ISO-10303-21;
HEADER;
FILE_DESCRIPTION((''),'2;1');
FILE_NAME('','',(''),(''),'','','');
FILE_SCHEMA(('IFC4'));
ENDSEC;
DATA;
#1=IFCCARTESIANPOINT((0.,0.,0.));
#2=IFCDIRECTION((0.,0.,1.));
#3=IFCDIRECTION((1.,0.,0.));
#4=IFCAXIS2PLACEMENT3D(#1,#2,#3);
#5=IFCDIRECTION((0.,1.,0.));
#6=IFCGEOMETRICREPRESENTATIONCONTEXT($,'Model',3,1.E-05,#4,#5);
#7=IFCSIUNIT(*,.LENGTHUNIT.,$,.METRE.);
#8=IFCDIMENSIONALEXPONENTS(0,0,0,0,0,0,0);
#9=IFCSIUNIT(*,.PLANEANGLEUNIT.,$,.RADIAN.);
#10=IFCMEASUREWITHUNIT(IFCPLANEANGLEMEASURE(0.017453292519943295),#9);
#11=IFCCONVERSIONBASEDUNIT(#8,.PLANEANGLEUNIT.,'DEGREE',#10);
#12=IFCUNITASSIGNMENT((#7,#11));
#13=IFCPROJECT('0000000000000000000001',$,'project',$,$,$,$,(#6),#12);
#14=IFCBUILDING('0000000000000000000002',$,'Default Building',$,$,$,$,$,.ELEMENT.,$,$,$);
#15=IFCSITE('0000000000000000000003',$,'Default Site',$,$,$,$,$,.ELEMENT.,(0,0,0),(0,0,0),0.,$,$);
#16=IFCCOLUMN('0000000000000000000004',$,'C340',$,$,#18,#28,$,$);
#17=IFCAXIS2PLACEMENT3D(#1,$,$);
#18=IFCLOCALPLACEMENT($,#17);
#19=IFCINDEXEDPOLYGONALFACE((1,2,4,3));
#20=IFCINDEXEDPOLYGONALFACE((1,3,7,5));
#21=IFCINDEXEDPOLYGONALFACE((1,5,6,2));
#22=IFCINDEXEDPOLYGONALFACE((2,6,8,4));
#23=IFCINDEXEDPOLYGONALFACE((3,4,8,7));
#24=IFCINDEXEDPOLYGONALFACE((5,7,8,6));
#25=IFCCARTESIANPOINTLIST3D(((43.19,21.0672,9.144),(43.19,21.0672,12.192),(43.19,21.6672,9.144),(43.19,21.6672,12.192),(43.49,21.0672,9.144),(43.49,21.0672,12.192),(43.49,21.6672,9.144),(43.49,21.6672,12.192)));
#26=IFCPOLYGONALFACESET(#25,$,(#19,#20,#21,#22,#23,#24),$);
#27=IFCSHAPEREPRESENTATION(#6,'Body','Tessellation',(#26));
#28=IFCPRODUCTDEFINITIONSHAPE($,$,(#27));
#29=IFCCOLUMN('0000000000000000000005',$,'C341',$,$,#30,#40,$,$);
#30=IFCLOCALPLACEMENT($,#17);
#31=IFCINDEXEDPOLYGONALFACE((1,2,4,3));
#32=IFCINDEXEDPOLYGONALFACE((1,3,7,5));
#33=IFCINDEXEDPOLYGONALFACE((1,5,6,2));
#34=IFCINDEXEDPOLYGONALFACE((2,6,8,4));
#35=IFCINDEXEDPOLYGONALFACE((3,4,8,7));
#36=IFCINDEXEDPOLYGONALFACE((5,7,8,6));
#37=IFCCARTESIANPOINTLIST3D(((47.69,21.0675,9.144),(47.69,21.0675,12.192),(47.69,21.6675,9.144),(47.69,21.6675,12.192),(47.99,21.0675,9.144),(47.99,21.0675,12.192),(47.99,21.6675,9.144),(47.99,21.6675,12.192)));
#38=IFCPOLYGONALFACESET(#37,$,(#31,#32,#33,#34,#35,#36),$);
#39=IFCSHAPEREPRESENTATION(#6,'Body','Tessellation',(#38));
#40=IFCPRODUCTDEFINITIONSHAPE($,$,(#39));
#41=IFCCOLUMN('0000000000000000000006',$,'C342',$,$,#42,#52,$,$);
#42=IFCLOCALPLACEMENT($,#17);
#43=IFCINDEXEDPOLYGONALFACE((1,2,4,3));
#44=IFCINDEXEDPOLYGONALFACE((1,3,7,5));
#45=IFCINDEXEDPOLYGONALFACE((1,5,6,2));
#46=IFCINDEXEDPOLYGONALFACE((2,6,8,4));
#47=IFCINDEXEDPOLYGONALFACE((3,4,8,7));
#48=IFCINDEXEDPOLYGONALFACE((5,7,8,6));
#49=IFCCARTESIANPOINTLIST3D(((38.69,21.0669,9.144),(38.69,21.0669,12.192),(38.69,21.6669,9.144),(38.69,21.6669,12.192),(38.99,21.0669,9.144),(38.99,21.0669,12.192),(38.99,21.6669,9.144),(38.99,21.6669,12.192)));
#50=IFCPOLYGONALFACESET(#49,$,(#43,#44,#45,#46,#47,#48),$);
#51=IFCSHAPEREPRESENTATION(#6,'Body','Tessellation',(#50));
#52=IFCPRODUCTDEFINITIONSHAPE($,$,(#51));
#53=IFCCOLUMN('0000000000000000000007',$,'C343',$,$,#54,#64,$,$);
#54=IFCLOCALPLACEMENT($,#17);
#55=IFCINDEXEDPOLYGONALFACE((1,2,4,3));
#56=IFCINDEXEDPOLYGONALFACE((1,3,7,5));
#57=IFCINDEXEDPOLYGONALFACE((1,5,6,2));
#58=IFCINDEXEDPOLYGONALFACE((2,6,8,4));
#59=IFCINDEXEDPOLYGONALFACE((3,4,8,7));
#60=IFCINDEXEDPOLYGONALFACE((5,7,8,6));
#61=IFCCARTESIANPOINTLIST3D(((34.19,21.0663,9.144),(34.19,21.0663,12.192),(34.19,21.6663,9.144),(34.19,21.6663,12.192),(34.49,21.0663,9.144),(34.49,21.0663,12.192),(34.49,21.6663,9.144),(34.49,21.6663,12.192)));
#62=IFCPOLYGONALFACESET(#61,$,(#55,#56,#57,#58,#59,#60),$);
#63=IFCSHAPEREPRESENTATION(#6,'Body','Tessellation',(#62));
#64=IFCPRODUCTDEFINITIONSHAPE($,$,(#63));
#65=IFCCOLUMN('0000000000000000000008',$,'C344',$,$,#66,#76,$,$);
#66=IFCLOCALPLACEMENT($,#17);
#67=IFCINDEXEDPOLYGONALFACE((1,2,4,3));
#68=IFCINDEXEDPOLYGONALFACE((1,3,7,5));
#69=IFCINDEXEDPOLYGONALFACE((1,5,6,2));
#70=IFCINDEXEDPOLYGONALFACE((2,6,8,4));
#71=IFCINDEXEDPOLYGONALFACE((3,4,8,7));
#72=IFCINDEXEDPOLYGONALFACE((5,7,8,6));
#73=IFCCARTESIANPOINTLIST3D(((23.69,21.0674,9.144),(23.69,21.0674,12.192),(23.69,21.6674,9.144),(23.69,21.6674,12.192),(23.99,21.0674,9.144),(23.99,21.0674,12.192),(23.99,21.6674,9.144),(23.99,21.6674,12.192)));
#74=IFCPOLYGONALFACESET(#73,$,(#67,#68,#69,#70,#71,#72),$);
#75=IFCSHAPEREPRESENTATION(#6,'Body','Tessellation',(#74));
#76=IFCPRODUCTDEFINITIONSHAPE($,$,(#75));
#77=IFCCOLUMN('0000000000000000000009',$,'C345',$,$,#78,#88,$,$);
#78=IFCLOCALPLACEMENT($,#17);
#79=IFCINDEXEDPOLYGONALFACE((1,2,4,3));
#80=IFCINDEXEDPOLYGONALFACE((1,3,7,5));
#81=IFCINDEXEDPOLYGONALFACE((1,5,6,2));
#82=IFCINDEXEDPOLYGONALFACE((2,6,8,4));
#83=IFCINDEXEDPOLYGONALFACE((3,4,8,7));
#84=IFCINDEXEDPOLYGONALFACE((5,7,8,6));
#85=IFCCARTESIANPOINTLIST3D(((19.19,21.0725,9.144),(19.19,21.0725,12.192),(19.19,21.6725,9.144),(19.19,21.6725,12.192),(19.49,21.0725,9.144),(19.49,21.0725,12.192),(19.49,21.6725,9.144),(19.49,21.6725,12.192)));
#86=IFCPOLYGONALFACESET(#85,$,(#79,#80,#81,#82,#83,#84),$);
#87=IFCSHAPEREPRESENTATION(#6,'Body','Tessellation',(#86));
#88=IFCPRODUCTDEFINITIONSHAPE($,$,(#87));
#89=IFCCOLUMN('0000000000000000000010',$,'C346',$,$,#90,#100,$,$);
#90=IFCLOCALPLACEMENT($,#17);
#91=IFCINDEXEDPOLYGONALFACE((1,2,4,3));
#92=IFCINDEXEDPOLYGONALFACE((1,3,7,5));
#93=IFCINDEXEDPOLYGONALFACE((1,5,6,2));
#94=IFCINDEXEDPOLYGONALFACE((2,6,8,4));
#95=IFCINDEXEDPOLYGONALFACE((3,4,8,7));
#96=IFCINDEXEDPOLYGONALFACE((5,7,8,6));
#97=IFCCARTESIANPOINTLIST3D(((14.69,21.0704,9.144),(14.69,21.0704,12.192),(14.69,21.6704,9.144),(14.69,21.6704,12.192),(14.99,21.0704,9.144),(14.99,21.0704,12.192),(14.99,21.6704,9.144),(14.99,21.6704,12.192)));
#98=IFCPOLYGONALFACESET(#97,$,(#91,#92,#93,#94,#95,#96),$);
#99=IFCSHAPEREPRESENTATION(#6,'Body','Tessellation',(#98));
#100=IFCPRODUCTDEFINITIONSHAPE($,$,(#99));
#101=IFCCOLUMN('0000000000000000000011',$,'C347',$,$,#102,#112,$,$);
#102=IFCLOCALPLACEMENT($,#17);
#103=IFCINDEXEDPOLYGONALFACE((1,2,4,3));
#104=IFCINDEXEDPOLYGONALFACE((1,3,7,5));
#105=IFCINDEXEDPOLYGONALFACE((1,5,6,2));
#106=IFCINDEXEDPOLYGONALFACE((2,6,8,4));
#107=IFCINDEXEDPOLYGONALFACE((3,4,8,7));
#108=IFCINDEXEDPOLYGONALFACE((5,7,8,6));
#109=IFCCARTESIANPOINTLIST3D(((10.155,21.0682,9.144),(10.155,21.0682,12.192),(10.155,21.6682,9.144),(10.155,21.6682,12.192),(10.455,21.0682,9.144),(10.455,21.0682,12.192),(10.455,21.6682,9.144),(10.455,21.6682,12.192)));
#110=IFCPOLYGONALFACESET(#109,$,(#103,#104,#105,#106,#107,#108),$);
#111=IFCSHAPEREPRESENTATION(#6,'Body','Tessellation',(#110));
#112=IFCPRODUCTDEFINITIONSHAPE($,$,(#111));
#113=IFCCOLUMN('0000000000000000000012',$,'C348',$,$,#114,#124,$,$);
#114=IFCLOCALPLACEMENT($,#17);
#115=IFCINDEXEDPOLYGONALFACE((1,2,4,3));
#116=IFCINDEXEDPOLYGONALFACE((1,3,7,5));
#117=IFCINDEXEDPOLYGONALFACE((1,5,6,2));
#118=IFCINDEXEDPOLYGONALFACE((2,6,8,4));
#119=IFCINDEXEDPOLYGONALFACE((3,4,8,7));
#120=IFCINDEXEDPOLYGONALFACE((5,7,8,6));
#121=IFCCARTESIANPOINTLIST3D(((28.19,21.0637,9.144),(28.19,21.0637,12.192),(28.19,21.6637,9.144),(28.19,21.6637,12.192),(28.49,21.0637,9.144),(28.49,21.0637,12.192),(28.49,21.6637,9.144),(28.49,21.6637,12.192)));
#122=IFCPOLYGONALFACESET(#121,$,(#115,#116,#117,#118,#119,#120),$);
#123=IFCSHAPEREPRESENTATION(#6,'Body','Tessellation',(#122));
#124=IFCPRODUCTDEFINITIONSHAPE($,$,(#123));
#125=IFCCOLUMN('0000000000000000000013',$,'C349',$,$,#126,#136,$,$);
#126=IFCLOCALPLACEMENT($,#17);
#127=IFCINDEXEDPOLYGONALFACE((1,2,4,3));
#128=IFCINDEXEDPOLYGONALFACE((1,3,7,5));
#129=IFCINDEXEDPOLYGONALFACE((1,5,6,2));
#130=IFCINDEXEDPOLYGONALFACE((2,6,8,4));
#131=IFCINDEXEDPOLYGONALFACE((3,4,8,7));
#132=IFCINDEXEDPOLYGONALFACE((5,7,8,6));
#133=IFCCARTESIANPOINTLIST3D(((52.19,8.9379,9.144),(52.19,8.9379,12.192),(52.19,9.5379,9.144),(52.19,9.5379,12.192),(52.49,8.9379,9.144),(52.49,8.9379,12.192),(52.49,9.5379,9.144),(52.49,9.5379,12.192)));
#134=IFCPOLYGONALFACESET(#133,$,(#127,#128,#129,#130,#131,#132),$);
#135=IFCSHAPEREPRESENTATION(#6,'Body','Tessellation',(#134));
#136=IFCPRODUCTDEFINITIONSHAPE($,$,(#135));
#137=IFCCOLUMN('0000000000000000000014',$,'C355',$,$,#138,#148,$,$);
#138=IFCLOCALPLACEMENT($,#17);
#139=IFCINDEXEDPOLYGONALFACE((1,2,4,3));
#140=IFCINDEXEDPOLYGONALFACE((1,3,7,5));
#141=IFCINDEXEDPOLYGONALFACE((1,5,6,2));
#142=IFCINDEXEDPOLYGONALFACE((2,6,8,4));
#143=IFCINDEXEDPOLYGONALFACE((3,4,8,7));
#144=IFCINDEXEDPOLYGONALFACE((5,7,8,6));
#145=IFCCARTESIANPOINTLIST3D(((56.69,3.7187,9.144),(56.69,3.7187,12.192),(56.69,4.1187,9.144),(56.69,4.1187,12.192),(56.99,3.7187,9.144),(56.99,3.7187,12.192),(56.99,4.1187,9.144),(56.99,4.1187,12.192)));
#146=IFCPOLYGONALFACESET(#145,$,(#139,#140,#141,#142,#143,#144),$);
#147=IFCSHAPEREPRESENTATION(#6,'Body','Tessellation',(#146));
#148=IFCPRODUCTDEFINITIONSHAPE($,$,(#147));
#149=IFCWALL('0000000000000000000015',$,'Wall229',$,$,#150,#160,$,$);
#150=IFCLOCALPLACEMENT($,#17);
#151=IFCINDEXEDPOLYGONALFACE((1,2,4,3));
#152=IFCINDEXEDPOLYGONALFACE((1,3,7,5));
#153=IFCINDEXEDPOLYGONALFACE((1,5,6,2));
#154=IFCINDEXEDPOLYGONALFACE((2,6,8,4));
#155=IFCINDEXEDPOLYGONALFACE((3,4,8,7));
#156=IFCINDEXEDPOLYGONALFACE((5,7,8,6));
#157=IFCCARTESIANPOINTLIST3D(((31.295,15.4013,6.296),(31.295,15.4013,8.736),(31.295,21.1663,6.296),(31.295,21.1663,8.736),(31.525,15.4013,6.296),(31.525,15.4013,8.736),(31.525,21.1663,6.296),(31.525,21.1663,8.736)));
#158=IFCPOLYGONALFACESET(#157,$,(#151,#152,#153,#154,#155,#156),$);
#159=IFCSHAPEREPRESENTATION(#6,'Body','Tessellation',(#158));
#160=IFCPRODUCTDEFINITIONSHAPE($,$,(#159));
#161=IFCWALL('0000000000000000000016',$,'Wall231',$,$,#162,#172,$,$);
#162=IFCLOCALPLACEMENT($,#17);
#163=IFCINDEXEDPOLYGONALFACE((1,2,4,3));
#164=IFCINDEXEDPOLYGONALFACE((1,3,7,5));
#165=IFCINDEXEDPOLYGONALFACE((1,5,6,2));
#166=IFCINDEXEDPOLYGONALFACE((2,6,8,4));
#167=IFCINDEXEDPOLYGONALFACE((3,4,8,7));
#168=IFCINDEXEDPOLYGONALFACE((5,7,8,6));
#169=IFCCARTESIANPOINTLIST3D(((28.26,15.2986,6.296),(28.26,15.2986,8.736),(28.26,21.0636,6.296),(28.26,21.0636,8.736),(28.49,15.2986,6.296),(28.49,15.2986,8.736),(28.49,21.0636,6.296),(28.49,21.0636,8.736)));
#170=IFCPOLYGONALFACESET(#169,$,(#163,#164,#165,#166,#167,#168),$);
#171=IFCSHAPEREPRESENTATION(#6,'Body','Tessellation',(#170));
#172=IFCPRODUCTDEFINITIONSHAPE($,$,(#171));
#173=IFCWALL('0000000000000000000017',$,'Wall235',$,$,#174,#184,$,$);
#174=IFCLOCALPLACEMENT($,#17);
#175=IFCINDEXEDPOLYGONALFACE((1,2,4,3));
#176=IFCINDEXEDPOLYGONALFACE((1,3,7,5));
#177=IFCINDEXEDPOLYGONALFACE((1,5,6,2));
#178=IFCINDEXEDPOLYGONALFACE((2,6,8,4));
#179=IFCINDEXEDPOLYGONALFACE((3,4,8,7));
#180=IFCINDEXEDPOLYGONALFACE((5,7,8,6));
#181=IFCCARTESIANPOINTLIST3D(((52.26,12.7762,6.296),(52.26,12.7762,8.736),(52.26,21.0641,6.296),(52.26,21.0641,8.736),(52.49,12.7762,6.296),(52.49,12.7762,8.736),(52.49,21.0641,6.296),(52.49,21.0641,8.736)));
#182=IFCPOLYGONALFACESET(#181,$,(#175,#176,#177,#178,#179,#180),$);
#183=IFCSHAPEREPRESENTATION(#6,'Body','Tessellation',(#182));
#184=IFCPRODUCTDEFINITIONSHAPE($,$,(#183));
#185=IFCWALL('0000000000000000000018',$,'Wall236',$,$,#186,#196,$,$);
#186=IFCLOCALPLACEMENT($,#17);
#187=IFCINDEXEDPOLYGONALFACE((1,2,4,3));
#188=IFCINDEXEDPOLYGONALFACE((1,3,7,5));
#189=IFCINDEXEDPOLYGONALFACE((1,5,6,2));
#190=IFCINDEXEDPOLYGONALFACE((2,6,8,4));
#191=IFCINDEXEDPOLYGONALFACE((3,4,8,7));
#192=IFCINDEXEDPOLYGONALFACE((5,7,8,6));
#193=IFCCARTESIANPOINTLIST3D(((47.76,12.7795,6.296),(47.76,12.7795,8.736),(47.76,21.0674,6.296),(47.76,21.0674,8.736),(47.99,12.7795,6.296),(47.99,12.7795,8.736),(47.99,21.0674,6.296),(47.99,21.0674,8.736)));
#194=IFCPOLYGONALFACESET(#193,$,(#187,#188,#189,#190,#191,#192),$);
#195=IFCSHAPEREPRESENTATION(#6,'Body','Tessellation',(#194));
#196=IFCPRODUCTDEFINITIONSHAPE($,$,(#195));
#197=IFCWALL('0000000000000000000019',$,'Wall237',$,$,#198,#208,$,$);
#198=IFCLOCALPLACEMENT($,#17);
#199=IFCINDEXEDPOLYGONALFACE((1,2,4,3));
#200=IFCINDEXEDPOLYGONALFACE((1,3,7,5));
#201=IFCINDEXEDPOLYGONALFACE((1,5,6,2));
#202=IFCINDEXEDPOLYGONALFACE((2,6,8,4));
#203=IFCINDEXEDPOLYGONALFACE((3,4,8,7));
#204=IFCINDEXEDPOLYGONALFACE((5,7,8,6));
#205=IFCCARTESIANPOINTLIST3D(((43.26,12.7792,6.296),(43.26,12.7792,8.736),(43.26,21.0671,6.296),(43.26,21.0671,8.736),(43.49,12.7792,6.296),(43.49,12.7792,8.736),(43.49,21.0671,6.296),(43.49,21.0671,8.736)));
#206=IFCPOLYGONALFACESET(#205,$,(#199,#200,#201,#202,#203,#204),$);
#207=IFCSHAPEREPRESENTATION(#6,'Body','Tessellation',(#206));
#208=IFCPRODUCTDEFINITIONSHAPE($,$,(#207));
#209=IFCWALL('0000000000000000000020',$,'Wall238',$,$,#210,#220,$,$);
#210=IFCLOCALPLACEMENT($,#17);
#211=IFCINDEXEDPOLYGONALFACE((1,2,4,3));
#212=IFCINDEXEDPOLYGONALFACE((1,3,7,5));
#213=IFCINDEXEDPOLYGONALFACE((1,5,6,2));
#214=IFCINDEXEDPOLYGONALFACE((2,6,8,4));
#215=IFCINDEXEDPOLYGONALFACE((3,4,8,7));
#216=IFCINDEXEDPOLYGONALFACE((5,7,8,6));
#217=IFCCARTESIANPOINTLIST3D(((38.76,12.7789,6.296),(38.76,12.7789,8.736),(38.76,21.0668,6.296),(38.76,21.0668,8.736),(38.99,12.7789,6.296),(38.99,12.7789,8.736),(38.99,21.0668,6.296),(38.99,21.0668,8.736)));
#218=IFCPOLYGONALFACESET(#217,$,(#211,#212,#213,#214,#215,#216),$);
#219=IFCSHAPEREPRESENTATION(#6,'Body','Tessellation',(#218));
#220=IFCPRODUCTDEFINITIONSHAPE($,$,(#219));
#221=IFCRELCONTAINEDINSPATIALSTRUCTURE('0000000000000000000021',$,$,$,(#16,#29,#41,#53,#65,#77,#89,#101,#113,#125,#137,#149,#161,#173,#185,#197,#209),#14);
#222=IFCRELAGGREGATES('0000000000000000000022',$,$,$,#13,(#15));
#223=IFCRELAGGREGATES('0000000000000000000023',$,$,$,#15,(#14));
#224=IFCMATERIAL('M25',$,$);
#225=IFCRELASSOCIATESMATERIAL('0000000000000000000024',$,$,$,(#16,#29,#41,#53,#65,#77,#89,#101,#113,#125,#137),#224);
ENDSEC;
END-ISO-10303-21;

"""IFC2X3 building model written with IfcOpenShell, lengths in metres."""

from ifc_helpers import new_model, entity, si_unit, converted_unit, direction, frame, frame_2d, origin_with_axes, place, context, project, spatial, rectangle, extrude, material, element, save


model = new_model("IFC2X3")

# Units and contexts
model_context = context("Model", 3, precision=1e-05, world=origin_with_axes(), true_north=direction((0.0, 1.0, 0.0)))
ifc_project = project(units=[si_unit("LENGTHUNIT", "METRE"), converted_unit("PLANEANGLEUNIT", "DEGREE", entity("IfcPlaneAngleMeasure", 0.017453292519943295), si_unit("PLANEANGLEUNIT", "RADIAN"), dimensions=[0, 0, 0, 0, 0, 0, 0])], contexts=[model_context])

# Site, building
site = spatial("IfcSite", under=ifc_project, Name="Default Site", CompositionType="ELEMENT", RefLatitude=(0, 0, 0), RefLongitude=(0, 0, 0), RefElevation=0.0)
building = spatial("IfcBuilding", under=site, Name="Default Building", CompositionType="ELEMENT")

# Columns
ifc_material = material(Name="M25")
placement = place(None, origin_with_axes())
element("IfcColumn", 1, at=placement, inside=building, material=ifc_material, Name="C340", context=model_context, shape_type="SweptSolid", body=[
    extrude(rectangle(XDim=0.3, YDim=0.6, at=frame_2d((0.0, 0.0), x_axis=(1.0, 0.0, 0.0))), frame((43.34, 21.3672, 9.144), z_axis=(0.0, 0.0, 1.0), x_axis=(1.0, 0.0, 0.0)), (0.0, 0.0, 1.0), 3.048),
])
element("IfcColumn", 2, at=placement, inside=building, material=ifc_material, Name="C341", context=model_context, shape_type="SweptSolid", body=[
    extrude(rectangle(XDim=0.3, YDim=0.6, at=frame_2d((0.0, 0.0), x_axis=(1.0, 0.0, 0.0))), frame((47.84, 21.3675, 9.144), z_axis=(0.0, 0.0, 1.0), x_axis=(1.0, 0.0, 0.0)), (0.0, 0.0, 1.0), 3.048),
])
element("IfcColumn", 3, at=placement, inside=building, material=ifc_material, Name="C342", context=model_context, shape_type="SweptSolid", body=[
    extrude(rectangle(XDim=0.3, YDim=0.6, at=frame_2d((0.0, 0.0), x_axis=(1.0, 0.0, 0.0))), frame((38.84, 21.3669, 9.144), z_axis=(0.0, 0.0, 1.0), x_axis=(1.0, 0.0, 0.0)), (0.0, 0.0, 1.0), 3.048),
])
element("IfcColumn", 4, at=placement, inside=building, material=ifc_material, Name="C343", context=model_context, shape_type="SweptSolid", body=[
    extrude(rectangle(XDim=0.3, YDim=0.6, at=frame_2d((0.0, 0.0), x_axis=(1.0, 0.0, 0.0))), frame((34.34, 21.3663, 9.144), z_axis=(0.0, 0.0, 1.0), x_axis=(1.0, 0.0, 0.0)), (0.0, 0.0, 1.0), 3.048),
])
element("IfcColumn", 5, at=placement, inside=building, material=ifc_material, Name="C344", context=model_context, shape_type="SweptSolid", body=[
    extrude(rectangle(XDim=0.3, YDim=0.6, at=frame_2d((0.0, 0.0), x_axis=(1.0, 0.0, 0.0))), frame((23.84, 21.3674, 9.144), z_axis=(0.0, 0.0, 1.0), x_axis=(1.0, 0.0, 0.0)), (0.0, 0.0, 1.0), 3.048),
])
element("IfcColumn", 6, at=placement, inside=building, material=ifc_material, Name="C345", context=model_context, shape_type="SweptSolid", body=[
    extrude(rectangle(XDim=0.3, YDim=0.6, at=frame_2d((0.0, 0.0), x_axis=(1.0, 0.0, 0.0))), frame((19.34, 21.3725, 9.144), z_axis=(0.0, 0.0, 1.0), x_axis=(1.0, 0.0, 0.0)), (0.0, 0.0, 1.0), 3.048),
])
element("IfcColumn", 7, at=placement, inside=building, material=ifc_material, Name="C346", context=model_context, shape_type="SweptSolid", body=[
    extrude(rectangle(XDim=0.3, YDim=0.6, at=frame_2d((0.0, 0.0), x_axis=(1.0, 0.0, 0.0))), frame((14.84, 21.3704, 9.144), z_axis=(0.0, 0.0, 1.0), x_axis=(1.0, 0.0, 0.0)), (0.0, 0.0, 1.0), 3.048),
])
element("IfcColumn", 8, at=placement, inside=building, material=ifc_material, Name="C347", context=model_context, shape_type="SweptSolid", body=[
    extrude(rectangle(XDim=0.3, YDim=0.6, at=frame_2d((0.0, 0.0), x_axis=(1.0, 0.0, 0.0))), frame((10.305, 21.3682, 9.144), z_axis=(0.0, 0.0, 1.0), x_axis=(1.0, 0.0, 0.0)), (0.0, 0.0, 1.0), 3.048),
])
element("IfcColumn", 9, at=placement, inside=building, material=ifc_material, Name="C348", context=model_context, shape_type="SweptSolid", body=[
    extrude(rectangle(XDim=0.3, YDim=0.6, at=frame_2d((0.0, 0.0), x_axis=(1.0, 0.0, 0.0))), frame((28.34, 21.3637, 9.144), z_axis=(0.0, 0.0, 1.0), x_axis=(1.0, 0.0, 0.0)), (0.0, 0.0, 1.0), 3.048),
])
element("IfcColumn", 10, at=placement, inside=building, material=ifc_material, Name="C349", context=model_context, shape_type="SweptSolid", body=[
    extrude(rectangle(XDim=0.3, YDim=0.6, at=frame_2d((0.0, 0.0), x_axis=(1.0, 0.0, 0.0))), frame((52.34, 9.2379, 9.144), z_axis=(0.0, 0.0, 1.0), x_axis=(1.0, 0.0, 0.0)), (0.0, 0.0, 1.0), 3.048),
])
element("IfcColumn", 11, at=placement, inside=building, material=ifc_material, Name="C355", context=model_context, shape_type="SweptSolid", body=[
    extrude(rectangle(XDim=0.3, YDim=0.4, at=frame_2d((0.0, 0.0), x_axis=(1.0, 0.0, 0.0))), frame((56.84, 3.9187, 9.144), z_axis=(0.0, 0.0, 1.0), x_axis=(1.0, 0.0, 0.0)), (0.0, 0.0, 1.0), 3.048),
])

# Walls
element("IfcWall", 12, at=placement, inside=building, Name="Wall229", context=model_context, shape_type="SweptSolid", body=[
    extrude(rectangle(XDim=5.765, YDim=0.23, at=frame_2d((0.0, 0.0), x_axis=(0.0, 1.0, 0.0))), frame((31.41, 18.2838, 6.296), z_axis=(0.0, 0.0, 1.0), x_axis=(1.0, 0.0, 0.0)), (0.0, 0.0, 1.0), 2.44),
])
element("IfcWall", 13, at=placement, inside=building, Name="Wall231", context=model_context, shape_type="SweptSolid", body=[
    extrude(rectangle(XDim=5.765, YDim=0.23, at=frame_2d((0.0, 0.0), x_axis=(0.0, 1.0, 0.0))), frame((28.375, 18.1811, 6.296), z_axis=(0.0, 0.0, 1.0), x_axis=(1.0, 0.0, 0.0)), (0.0, 0.0, 1.0), 2.44),
])
element("IfcWall", 14, at=placement, inside=building, Name="Wall235", context=model_context, shape_type="SweptSolid", body=[
    extrude(rectangle(XDim=8.2879, YDim=0.23, at=frame_2d((0.0, 0.0), x_axis=(0.0, 1.0, 0.0))), frame((52.375, 16.9201, 6.296), z_axis=(0.0, 0.0, 1.0), x_axis=(1.0, 0.0, 0.0)), (0.0, 0.0, 1.0), 2.44),
])
element("IfcWall", 15, at=placement, inside=building, Name="Wall236", context=model_context, shape_type="SweptSolid", body=[
    extrude(rectangle(XDim=8.2879, YDim=0.23, at=frame_2d((0.0, 0.0), x_axis=(0.0, 1.0, 0.0))), frame((47.875, 16.9235, 6.296), z_axis=(0.0, 0.0, 1.0), x_axis=(1.0, 0.0, 0.0)), (0.0, 0.0, 1.0), 2.44),
])
element("IfcWall", 16, at=placement, inside=building, Name="Wall237", context=model_context, shape_type="SweptSolid", body=[
    extrude(rectangle(XDim=8.2879, YDim=0.23, at=frame_2d((0.0, 0.0), x_axis=(0.0, 1.0, 0.0))), frame((43.375, 16.9231, 6.296), z_axis=(0.0, 0.0, 1.0), x_axis=(1.0, 0.0, 0.0)), (0.0, 0.0, 1.0), 2.44),
])
element("IfcWall", 17, at=placement, inside=building, Name="Wall238", context=model_context, shape_type="SweptSolid", body=[
    extrude(rectangle(XDim=8.2879, YDim=0.23, at=frame_2d((0.0, 0.0), x_axis=(0.0, 1.0, 0.0))), frame((38.875, 16.9229, 6.296), z_axis=(0.0, 0.0, 1.0), x_axis=(1.0, 0.0, 0.0)), (0.0, 0.0, 1.0), 2.44),
])

save(model, "model.ifc")
